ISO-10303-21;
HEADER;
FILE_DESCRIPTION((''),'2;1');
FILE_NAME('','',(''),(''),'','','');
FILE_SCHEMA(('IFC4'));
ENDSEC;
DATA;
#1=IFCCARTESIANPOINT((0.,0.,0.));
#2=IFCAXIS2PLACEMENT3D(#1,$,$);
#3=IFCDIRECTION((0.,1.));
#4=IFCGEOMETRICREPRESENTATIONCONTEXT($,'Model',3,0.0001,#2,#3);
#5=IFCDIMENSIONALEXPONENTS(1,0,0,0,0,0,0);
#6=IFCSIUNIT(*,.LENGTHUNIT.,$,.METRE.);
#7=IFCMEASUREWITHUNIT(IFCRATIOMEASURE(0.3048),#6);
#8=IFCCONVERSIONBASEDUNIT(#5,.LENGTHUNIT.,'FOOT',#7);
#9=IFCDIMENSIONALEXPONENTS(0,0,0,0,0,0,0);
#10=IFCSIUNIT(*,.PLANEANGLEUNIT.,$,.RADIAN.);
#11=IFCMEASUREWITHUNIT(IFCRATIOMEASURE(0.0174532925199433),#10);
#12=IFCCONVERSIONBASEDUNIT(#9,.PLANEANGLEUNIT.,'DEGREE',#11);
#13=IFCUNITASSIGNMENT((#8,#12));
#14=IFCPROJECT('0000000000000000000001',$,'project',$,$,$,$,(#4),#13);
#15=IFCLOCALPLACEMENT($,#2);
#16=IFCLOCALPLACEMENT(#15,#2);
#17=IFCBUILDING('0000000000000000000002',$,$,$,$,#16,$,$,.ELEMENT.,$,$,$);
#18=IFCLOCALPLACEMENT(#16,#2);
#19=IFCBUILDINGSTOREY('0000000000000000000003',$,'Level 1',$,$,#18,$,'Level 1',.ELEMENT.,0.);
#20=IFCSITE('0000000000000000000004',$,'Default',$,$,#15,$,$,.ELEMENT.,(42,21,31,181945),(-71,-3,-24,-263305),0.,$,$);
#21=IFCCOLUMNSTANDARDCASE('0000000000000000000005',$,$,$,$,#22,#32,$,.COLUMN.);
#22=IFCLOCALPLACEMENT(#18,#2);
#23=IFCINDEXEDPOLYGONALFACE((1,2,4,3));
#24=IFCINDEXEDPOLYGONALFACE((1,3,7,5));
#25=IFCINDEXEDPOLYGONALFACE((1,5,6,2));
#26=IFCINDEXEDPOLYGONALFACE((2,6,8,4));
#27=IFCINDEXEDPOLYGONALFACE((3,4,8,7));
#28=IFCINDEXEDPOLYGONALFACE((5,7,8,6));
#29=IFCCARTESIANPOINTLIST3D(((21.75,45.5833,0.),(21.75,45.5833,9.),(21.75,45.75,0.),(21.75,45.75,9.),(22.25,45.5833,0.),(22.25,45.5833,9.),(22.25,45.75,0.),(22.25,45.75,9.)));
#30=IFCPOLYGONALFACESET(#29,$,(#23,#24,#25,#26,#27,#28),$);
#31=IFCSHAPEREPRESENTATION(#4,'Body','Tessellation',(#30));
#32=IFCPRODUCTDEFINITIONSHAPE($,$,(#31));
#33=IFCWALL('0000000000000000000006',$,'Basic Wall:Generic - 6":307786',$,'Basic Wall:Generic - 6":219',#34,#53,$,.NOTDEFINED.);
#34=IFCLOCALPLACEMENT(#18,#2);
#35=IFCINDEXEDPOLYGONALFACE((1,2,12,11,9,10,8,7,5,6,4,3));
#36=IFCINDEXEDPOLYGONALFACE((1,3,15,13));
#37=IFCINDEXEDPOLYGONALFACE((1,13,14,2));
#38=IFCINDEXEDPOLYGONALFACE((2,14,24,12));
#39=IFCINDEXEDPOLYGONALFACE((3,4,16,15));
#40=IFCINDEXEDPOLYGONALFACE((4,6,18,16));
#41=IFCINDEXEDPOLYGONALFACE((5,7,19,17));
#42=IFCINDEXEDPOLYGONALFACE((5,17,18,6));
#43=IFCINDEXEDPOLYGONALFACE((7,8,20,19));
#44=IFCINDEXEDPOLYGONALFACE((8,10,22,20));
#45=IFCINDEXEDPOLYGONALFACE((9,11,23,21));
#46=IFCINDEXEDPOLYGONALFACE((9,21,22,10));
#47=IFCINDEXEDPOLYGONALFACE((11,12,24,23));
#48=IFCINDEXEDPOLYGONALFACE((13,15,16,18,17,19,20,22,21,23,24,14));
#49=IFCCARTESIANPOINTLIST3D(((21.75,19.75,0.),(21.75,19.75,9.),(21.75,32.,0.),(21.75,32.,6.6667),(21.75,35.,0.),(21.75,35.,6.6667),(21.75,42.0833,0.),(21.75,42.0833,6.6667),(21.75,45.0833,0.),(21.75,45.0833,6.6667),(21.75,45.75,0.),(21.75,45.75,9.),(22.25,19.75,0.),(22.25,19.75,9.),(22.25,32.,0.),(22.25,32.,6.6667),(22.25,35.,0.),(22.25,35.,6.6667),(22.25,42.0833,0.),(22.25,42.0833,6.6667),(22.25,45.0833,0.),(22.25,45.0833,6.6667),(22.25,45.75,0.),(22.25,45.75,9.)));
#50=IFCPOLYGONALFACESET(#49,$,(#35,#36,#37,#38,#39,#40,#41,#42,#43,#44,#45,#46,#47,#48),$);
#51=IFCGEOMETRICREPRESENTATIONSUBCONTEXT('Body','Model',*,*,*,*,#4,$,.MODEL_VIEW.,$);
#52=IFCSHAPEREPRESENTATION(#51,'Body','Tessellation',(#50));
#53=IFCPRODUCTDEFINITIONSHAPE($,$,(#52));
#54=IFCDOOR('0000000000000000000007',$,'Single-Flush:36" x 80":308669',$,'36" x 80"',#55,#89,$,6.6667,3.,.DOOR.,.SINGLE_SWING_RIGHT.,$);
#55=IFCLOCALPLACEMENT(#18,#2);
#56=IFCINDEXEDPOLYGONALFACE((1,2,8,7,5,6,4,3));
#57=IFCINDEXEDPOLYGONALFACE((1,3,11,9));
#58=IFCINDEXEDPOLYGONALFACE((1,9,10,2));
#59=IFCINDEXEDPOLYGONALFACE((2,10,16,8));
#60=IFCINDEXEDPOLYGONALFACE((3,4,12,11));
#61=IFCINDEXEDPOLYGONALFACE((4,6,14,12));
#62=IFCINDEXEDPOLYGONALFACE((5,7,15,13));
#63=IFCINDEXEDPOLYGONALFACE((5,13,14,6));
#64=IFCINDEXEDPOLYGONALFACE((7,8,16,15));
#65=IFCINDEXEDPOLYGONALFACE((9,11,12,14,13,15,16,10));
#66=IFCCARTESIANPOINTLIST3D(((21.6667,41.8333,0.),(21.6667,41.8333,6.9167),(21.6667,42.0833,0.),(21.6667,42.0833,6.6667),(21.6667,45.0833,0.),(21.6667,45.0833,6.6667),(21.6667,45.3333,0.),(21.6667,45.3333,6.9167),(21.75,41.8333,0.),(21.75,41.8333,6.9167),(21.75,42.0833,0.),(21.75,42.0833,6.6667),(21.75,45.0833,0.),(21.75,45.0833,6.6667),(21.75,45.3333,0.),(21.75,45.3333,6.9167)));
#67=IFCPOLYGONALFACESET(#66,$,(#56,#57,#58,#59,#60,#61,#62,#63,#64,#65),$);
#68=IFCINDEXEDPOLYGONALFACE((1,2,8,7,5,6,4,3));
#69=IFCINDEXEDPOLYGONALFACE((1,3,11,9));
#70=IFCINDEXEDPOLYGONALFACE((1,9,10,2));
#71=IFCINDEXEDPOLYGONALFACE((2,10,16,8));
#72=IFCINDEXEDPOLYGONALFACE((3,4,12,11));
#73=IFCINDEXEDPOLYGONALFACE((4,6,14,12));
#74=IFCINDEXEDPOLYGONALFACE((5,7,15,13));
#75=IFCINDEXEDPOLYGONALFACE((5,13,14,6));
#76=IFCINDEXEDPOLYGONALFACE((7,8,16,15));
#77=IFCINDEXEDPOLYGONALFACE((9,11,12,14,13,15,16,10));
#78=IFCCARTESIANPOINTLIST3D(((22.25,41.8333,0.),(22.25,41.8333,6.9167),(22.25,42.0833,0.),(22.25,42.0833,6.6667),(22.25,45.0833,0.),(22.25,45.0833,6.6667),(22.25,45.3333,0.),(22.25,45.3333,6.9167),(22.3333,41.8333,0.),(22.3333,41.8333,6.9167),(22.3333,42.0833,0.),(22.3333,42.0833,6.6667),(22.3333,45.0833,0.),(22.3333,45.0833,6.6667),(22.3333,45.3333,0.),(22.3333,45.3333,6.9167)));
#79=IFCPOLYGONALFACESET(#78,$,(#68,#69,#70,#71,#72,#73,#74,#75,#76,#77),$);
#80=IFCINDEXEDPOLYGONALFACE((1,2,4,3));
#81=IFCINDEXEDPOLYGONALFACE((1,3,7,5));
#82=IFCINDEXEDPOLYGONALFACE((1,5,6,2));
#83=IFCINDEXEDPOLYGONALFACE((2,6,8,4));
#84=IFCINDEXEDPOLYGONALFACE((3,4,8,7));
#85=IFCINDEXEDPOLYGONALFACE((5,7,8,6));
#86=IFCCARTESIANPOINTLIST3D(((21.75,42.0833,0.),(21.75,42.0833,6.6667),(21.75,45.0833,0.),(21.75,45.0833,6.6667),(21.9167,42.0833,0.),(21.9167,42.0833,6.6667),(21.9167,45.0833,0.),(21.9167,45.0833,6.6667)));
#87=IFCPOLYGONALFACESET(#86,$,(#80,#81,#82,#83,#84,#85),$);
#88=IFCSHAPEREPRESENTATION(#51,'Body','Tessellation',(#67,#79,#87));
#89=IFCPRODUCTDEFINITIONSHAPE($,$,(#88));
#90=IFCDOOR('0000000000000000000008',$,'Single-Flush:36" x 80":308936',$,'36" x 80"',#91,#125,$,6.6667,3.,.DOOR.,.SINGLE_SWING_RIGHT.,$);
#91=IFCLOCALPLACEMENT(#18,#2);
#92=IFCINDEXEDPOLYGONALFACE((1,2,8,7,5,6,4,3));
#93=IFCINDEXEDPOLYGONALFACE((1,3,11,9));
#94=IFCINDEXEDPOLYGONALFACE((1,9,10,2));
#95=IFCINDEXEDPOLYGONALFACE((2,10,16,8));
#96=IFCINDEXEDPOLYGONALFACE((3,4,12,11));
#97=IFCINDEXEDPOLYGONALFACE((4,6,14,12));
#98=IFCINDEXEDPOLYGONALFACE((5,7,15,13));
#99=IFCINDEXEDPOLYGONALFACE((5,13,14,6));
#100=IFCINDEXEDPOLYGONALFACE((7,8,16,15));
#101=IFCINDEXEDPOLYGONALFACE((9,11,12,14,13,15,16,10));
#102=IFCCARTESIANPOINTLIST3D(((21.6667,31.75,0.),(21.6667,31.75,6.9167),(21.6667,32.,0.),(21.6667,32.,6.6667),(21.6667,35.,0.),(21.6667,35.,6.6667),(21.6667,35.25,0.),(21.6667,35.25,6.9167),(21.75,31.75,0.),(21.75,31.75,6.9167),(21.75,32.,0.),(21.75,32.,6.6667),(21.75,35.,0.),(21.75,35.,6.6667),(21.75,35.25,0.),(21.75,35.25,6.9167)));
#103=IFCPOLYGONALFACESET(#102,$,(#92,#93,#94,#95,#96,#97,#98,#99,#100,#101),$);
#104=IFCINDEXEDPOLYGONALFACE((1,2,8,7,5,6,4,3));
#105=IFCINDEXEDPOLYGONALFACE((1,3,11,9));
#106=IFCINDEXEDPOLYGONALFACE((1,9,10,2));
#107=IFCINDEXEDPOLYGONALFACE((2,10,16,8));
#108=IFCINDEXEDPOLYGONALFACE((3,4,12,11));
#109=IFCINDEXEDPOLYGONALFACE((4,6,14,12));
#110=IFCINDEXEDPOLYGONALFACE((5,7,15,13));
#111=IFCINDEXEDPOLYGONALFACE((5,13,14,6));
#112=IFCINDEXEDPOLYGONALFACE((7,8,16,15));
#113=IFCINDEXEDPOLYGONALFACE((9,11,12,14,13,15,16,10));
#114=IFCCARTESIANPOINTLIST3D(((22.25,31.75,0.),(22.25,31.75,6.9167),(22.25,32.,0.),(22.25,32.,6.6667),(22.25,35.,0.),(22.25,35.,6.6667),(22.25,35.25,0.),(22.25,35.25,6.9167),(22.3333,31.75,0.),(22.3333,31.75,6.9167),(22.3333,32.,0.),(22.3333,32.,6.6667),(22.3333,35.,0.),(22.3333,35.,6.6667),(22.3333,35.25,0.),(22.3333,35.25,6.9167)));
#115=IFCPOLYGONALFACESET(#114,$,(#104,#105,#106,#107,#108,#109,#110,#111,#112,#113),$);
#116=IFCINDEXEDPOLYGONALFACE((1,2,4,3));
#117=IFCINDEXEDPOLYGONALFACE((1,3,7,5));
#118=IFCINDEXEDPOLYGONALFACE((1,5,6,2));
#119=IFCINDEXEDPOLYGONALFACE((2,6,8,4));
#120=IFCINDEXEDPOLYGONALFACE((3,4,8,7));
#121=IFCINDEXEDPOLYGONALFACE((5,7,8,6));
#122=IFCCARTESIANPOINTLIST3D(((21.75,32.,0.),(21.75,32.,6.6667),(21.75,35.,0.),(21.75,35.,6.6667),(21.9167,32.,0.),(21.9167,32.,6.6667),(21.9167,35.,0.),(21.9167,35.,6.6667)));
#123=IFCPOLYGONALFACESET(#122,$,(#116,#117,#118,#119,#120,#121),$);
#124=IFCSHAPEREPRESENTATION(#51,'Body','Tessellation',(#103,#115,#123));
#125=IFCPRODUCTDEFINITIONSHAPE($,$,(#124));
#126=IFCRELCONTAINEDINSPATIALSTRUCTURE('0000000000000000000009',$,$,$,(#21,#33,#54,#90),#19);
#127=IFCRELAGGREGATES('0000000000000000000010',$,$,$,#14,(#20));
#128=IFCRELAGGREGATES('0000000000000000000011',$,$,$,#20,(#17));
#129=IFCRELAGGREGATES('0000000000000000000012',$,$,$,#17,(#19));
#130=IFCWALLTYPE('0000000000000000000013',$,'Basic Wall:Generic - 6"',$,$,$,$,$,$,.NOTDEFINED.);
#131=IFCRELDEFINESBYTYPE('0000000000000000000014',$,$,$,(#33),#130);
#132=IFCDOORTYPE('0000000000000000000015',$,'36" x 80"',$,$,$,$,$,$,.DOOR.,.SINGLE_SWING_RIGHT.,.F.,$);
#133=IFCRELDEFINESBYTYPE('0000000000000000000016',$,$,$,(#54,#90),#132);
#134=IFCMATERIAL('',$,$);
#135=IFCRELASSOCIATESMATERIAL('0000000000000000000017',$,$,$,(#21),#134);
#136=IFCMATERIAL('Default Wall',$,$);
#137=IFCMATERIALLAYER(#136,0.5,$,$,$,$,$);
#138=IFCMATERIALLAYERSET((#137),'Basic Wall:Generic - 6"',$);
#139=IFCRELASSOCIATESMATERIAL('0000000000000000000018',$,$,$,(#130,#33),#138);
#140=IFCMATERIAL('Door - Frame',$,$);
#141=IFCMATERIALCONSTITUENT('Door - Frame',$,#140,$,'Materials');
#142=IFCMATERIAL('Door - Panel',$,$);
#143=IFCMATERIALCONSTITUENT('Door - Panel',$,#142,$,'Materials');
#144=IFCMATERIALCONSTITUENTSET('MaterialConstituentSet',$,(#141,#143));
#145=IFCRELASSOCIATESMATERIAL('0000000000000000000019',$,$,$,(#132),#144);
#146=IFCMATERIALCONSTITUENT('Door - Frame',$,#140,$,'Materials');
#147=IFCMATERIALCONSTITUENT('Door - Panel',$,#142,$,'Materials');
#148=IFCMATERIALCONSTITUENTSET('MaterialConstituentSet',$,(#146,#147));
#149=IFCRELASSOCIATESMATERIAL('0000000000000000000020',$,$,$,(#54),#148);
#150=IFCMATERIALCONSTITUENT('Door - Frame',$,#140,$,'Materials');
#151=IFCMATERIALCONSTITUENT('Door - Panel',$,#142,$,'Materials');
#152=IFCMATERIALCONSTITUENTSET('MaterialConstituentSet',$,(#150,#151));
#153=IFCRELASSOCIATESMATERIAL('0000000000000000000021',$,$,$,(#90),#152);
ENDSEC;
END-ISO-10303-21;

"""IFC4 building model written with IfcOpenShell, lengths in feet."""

from ifc_helpers import new_model, entity, si_unit, converted_unit, direction, frame, frame_2d, origin, origin_2d_with_axis, place, context, subcontext, project, spatial, polyline, rectangle, outline, extrude, clip, bounded_halfspace, source, transform, mapped, material, layer, layer_set, layer_usage, constituent, constituent_set, type_object, type_shapes, element, fill, save


model = new_model("IFC4")

# Units and contexts
model_context = context("Model", 3, precision=0.0001, world=origin(), true_north=direction((0.0, 1.0)))
body_context = subcontext(model_context, "Body", "Model", "MODEL_VIEW")
ifc_project = project(units=[converted_unit("LENGTHUNIT", "FOOT", entity("IfcRatioMeasure", 0.3048), si_unit("LENGTHUNIT", "METRE"), dimensions=[1, 0, 0, 0, 0, 0, 0]), converted_unit("PLANEANGLEUNIT", "DEGREE", entity("IfcRatioMeasure", 0.0174532925199433), si_unit("PLANEANGLEUNIT", "RADIAN"), dimensions=[0, 0, 0, 0, 0, 0, 0])], contexts=[model_context])

# Site, building, storey
site_placement = place(None, origin())
site = spatial("IfcSite", under=ifc_project, at=site_placement, Name="Default", CompositionType="ELEMENT", RefLatitude=(42, 21, 31, 181945), RefLongitude=(-71, -3, -24, -263305), RefElevation=0.0)
building_placement = place(site_placement, origin())
building = spatial("IfcBuilding", under=site, at=building_placement, CompositionType="ELEMENT")
storey_placement = place(building_placement, origin())
storey = spatial("IfcBuildingStorey", under=building, at=storey_placement, Name="Level 1", LongName="Level 1", CompositionType="ELEMENT", Elevation=0.0)

# Column
ifc_material_1 = material(Name="")
wall_placement = place(storey_placement, frame((22.0, 45.75, 0.0), z_axis=(0.0, 0.0, 1.0), x_axis=(0.0, -1.0, 0.0)))
for number, where, z_axis, x_axis in (
    (1, (0.0833, 0.0, 0.0), (0.0, 0.0, 1.0), (1.0, 0.0, 0.0)),
):
    element("IfcColumnStandardCase", number, at=place(wall_placement, frame(where, z_axis=z_axis, x_axis=x_axis)), inside=storey, material=ifc_material_1, PredefinedType="COLUMN", context=model_context, shape_type="SweptSolid", body=[
        extrude(rectangle(XDim=0.1667, YDim=0.5), origin(), (0.0, 0.0, 1.0), 9.0),
    ])

# Wall, openings, doors
ifc_material_2 = material(Name="Default Wall")
ifc_layer = layer(ifc_material_2, 0.5)
ifc_layer_set = layer_set([ifc_layer], Name="Basic Wall:Generic - 6\"")
ifc_layer_usage = layer_usage(ifc_layer_set, "AXIS2", "NEGATIVE", 0.25)
wall_type = type_object("IfcWallType", Name="Basic Wall:Generic - 6\"", PredefinedType="NOTDEFINED", material=ifc_layer_set)
wall = element("IfcWall", 2, at=wall_placement, inside=storey, type_object=wall_type, material=ifc_layer_usage, Name="Basic Wall:Generic - 6\":307786", ObjectType="Basic Wall:Generic - 6\":219", PredefinedType="NOTDEFINED", context=body_context, shape_type="Clipping", body=[
    clip(extrude(rectangle(XDim=26.0, YDim=0.5, at=frame_2d((13.0, 0.0), x_axis=(-1.0, 0.0))), origin(), (0.0, 0.0, 1.0), 9.0), bounded_halfspace(frame((0.0, -0.25, 9.0), z_axis=(0.0, 0.0, -1.0), x_axis=(-1.0, 0.0, 0.0)), True, frame((0.0, -0.25, 9.0)), polyline([(0.0, 0.0), (9.5, 0.0), (10.0, 0.0), (25.5, 0.0), (25.5, 0.5), (0.0, 0.5), (0.0, 0.0)]))),
])
opening_1_placement = place(wall_placement, frame((3.6667, 0.25, 0.0)))
opening_1 = element("IfcOpeningElement", 3, at=opening_1_placement, cuts=wall, ObjectType="Opening", PredefinedType="OPENING", context=body_context, shape_type="SweptSolid", body=[
    extrude(rectangle(XDim=3.0, YDim=6.6667, at=frame_2d((3.3333, 1.5), x_axis=(0.0, 1.0))), frame((0.0, 0.0, 0.0), z_axis=(0.0, -1.0, 0.0), x_axis=(0.0, 0.0, 1.0)), (0.0, 0.0, 1.0), 0.5),
])
opening_2_placement = place(wall_placement, frame((13.75, 0.25, 0.0)))
opening_2 = element("IfcOpeningElement", 4, at=opening_2_placement, cuts=wall, ObjectType="Opening", PredefinedType="OPENING", context=body_context, shape_type="SweptSolid", body=[
    extrude(rectangle(XDim=3.0, YDim=6.6667, at=frame_2d((3.3333, 1.5), x_axis=(0.0, 1.0))), frame((0.0, 0.0, 0.0), z_axis=(0.0, -1.0, 0.0), x_axis=(0.0, 0.0, 1.0)), (0.0, 0.0, 1.0), 0.5),
])
ifc_material_3 = material(Name="Door - Frame")
ifc_constituent_1 = constituent(ifc_material_3, Name="Door - Frame", Category="Materials")
ifc_material_4 = material(Name="Door - Panel")
ifc_constituent_2 = constituent(ifc_material_4, Name="Door - Panel", Category="Materials")
ifc_constituent_set_1 = constituent_set(constituents=[ifc_constituent_1, ifc_constituent_2], Name="MaterialConstituentSet")
ifc_constituent_3 = constituent(ifc_material_3, Name="Door - Frame", Category="Materials")
ifc_constituent_4 = constituent(ifc_material_4, Name="Door - Panel", Category="Materials")
ifc_constituent_set_2 = constituent_set(constituents=[ifc_constituent_3, ifc_constituent_4], Name="MaterialConstituentSet")
door_type = type_object("IfcDoorType", Name="36\" x 80\"", OperationType="SINGLE_SWING_RIGHT", ParameterTakesPrecedence=False, PredefinedType="DOOR", material=ifc_constituent_set_2)
shared_shape = source(origin(), body_context, "Body", "SweptSolid", [
    extrude(outline(polyline([(-1.75, -3.5208), (1.75, -3.5208), (1.75, 3.3958), (1.5, 3.3958), (1.5, -3.2708), (-1.5, -3.2708), (-1.5, 3.3958), (-1.75, 3.3958), (-1.75, -3.5208)])), frame((1.5, 0.5, 3.3958), z_axis=(0.0, 1.0, 0.0), x_axis=(1.0, 0.0, 0.0)), (0.0, 0.0, 1.0), 0.0833),
    extrude(outline(polyline([(-3.5208, -1.75), (3.3958, -1.75), (3.3958, -1.5), (-3.2708, -1.5), (-3.2708, 1.5), (3.3958, 1.5), (3.3958, 1.75), (-3.5208, 1.75), (-3.5208, -1.75)])), frame((1.5, -0.0833, 3.3958), z_axis=(0.0, 1.0, 0.0), x_axis=(0.0, 0.0, -1.0)), (0.0, 0.0, 1.0), 0.0833),
    extrude(rectangle(XDim=0.1667, YDim=3.0, at=origin_2d_with_axis()), frame((1.5, 0.4167, 0.0), z_axis=(0.0, 0.0, 1.0), x_axis=(0.0, 1.0, 0.0)), (0.0, 0.0, 1.0), 6.6667),
])
type_shapes(door_type, [shared_shape])
door_1_placement = place(opening_1_placement, frame((0.0, 0.0, 0.0), z_axis=(0.0, 0.0, 1.0), x_axis=(-1.0, 0.0, 0.0)))
door_1 = element("IfcDoor", 5, at=door_1_placement, inside=storey, type_object=door_type, material=ifc_constituent_set_1, Name="Single-Flush:36\" x 80\":308669", ObjectType="36\" x 80\"", OperationType="SINGLE_SWING_RIGHT", OverallHeight=6.6667, OverallWidth=3.0, PredefinedType="DOOR", context=body_context, shape_type="MappedRepresentation", body=[
    mapped(shared_shape, transform((0.0, 0.0, 0.0), scale=1.0)),
])
fill(opening_1, door_1)
ifc_constituent_5 = constituent(ifc_material_3, Name="Door - Frame", Category="Materials")
ifc_constituent_6 = constituent(ifc_material_4, Name="Door - Panel", Category="Materials")
ifc_constituent_set_3 = constituent_set(constituents=[ifc_constituent_5, ifc_constituent_6], Name="MaterialConstituentSet")
door_2_placement = place(opening_2_placement, frame((0.0, 0.0, 0.0), z_axis=(0.0, 0.0, 1.0), x_axis=(-1.0, 0.0, 0.0)))
door_2 = element("IfcDoor", 6, at=door_2_placement, inside=storey, type_object=door_type, material=ifc_constituent_set_3, Name="Single-Flush:36\" x 80\":308936", ObjectType="36\" x 80\"", OperationType="SINGLE_SWING_RIGHT", OverallHeight=6.6667, OverallWidth=3.0, PredefinedType="DOOR", context=body_context, shape_type="MappedRepresentation", body=[
    mapped(shared_shape, transform((0.0, 0.0, 0.0), scale=1.0)),
])
fill(opening_2, door_2)

save(model, "model.ifc")
